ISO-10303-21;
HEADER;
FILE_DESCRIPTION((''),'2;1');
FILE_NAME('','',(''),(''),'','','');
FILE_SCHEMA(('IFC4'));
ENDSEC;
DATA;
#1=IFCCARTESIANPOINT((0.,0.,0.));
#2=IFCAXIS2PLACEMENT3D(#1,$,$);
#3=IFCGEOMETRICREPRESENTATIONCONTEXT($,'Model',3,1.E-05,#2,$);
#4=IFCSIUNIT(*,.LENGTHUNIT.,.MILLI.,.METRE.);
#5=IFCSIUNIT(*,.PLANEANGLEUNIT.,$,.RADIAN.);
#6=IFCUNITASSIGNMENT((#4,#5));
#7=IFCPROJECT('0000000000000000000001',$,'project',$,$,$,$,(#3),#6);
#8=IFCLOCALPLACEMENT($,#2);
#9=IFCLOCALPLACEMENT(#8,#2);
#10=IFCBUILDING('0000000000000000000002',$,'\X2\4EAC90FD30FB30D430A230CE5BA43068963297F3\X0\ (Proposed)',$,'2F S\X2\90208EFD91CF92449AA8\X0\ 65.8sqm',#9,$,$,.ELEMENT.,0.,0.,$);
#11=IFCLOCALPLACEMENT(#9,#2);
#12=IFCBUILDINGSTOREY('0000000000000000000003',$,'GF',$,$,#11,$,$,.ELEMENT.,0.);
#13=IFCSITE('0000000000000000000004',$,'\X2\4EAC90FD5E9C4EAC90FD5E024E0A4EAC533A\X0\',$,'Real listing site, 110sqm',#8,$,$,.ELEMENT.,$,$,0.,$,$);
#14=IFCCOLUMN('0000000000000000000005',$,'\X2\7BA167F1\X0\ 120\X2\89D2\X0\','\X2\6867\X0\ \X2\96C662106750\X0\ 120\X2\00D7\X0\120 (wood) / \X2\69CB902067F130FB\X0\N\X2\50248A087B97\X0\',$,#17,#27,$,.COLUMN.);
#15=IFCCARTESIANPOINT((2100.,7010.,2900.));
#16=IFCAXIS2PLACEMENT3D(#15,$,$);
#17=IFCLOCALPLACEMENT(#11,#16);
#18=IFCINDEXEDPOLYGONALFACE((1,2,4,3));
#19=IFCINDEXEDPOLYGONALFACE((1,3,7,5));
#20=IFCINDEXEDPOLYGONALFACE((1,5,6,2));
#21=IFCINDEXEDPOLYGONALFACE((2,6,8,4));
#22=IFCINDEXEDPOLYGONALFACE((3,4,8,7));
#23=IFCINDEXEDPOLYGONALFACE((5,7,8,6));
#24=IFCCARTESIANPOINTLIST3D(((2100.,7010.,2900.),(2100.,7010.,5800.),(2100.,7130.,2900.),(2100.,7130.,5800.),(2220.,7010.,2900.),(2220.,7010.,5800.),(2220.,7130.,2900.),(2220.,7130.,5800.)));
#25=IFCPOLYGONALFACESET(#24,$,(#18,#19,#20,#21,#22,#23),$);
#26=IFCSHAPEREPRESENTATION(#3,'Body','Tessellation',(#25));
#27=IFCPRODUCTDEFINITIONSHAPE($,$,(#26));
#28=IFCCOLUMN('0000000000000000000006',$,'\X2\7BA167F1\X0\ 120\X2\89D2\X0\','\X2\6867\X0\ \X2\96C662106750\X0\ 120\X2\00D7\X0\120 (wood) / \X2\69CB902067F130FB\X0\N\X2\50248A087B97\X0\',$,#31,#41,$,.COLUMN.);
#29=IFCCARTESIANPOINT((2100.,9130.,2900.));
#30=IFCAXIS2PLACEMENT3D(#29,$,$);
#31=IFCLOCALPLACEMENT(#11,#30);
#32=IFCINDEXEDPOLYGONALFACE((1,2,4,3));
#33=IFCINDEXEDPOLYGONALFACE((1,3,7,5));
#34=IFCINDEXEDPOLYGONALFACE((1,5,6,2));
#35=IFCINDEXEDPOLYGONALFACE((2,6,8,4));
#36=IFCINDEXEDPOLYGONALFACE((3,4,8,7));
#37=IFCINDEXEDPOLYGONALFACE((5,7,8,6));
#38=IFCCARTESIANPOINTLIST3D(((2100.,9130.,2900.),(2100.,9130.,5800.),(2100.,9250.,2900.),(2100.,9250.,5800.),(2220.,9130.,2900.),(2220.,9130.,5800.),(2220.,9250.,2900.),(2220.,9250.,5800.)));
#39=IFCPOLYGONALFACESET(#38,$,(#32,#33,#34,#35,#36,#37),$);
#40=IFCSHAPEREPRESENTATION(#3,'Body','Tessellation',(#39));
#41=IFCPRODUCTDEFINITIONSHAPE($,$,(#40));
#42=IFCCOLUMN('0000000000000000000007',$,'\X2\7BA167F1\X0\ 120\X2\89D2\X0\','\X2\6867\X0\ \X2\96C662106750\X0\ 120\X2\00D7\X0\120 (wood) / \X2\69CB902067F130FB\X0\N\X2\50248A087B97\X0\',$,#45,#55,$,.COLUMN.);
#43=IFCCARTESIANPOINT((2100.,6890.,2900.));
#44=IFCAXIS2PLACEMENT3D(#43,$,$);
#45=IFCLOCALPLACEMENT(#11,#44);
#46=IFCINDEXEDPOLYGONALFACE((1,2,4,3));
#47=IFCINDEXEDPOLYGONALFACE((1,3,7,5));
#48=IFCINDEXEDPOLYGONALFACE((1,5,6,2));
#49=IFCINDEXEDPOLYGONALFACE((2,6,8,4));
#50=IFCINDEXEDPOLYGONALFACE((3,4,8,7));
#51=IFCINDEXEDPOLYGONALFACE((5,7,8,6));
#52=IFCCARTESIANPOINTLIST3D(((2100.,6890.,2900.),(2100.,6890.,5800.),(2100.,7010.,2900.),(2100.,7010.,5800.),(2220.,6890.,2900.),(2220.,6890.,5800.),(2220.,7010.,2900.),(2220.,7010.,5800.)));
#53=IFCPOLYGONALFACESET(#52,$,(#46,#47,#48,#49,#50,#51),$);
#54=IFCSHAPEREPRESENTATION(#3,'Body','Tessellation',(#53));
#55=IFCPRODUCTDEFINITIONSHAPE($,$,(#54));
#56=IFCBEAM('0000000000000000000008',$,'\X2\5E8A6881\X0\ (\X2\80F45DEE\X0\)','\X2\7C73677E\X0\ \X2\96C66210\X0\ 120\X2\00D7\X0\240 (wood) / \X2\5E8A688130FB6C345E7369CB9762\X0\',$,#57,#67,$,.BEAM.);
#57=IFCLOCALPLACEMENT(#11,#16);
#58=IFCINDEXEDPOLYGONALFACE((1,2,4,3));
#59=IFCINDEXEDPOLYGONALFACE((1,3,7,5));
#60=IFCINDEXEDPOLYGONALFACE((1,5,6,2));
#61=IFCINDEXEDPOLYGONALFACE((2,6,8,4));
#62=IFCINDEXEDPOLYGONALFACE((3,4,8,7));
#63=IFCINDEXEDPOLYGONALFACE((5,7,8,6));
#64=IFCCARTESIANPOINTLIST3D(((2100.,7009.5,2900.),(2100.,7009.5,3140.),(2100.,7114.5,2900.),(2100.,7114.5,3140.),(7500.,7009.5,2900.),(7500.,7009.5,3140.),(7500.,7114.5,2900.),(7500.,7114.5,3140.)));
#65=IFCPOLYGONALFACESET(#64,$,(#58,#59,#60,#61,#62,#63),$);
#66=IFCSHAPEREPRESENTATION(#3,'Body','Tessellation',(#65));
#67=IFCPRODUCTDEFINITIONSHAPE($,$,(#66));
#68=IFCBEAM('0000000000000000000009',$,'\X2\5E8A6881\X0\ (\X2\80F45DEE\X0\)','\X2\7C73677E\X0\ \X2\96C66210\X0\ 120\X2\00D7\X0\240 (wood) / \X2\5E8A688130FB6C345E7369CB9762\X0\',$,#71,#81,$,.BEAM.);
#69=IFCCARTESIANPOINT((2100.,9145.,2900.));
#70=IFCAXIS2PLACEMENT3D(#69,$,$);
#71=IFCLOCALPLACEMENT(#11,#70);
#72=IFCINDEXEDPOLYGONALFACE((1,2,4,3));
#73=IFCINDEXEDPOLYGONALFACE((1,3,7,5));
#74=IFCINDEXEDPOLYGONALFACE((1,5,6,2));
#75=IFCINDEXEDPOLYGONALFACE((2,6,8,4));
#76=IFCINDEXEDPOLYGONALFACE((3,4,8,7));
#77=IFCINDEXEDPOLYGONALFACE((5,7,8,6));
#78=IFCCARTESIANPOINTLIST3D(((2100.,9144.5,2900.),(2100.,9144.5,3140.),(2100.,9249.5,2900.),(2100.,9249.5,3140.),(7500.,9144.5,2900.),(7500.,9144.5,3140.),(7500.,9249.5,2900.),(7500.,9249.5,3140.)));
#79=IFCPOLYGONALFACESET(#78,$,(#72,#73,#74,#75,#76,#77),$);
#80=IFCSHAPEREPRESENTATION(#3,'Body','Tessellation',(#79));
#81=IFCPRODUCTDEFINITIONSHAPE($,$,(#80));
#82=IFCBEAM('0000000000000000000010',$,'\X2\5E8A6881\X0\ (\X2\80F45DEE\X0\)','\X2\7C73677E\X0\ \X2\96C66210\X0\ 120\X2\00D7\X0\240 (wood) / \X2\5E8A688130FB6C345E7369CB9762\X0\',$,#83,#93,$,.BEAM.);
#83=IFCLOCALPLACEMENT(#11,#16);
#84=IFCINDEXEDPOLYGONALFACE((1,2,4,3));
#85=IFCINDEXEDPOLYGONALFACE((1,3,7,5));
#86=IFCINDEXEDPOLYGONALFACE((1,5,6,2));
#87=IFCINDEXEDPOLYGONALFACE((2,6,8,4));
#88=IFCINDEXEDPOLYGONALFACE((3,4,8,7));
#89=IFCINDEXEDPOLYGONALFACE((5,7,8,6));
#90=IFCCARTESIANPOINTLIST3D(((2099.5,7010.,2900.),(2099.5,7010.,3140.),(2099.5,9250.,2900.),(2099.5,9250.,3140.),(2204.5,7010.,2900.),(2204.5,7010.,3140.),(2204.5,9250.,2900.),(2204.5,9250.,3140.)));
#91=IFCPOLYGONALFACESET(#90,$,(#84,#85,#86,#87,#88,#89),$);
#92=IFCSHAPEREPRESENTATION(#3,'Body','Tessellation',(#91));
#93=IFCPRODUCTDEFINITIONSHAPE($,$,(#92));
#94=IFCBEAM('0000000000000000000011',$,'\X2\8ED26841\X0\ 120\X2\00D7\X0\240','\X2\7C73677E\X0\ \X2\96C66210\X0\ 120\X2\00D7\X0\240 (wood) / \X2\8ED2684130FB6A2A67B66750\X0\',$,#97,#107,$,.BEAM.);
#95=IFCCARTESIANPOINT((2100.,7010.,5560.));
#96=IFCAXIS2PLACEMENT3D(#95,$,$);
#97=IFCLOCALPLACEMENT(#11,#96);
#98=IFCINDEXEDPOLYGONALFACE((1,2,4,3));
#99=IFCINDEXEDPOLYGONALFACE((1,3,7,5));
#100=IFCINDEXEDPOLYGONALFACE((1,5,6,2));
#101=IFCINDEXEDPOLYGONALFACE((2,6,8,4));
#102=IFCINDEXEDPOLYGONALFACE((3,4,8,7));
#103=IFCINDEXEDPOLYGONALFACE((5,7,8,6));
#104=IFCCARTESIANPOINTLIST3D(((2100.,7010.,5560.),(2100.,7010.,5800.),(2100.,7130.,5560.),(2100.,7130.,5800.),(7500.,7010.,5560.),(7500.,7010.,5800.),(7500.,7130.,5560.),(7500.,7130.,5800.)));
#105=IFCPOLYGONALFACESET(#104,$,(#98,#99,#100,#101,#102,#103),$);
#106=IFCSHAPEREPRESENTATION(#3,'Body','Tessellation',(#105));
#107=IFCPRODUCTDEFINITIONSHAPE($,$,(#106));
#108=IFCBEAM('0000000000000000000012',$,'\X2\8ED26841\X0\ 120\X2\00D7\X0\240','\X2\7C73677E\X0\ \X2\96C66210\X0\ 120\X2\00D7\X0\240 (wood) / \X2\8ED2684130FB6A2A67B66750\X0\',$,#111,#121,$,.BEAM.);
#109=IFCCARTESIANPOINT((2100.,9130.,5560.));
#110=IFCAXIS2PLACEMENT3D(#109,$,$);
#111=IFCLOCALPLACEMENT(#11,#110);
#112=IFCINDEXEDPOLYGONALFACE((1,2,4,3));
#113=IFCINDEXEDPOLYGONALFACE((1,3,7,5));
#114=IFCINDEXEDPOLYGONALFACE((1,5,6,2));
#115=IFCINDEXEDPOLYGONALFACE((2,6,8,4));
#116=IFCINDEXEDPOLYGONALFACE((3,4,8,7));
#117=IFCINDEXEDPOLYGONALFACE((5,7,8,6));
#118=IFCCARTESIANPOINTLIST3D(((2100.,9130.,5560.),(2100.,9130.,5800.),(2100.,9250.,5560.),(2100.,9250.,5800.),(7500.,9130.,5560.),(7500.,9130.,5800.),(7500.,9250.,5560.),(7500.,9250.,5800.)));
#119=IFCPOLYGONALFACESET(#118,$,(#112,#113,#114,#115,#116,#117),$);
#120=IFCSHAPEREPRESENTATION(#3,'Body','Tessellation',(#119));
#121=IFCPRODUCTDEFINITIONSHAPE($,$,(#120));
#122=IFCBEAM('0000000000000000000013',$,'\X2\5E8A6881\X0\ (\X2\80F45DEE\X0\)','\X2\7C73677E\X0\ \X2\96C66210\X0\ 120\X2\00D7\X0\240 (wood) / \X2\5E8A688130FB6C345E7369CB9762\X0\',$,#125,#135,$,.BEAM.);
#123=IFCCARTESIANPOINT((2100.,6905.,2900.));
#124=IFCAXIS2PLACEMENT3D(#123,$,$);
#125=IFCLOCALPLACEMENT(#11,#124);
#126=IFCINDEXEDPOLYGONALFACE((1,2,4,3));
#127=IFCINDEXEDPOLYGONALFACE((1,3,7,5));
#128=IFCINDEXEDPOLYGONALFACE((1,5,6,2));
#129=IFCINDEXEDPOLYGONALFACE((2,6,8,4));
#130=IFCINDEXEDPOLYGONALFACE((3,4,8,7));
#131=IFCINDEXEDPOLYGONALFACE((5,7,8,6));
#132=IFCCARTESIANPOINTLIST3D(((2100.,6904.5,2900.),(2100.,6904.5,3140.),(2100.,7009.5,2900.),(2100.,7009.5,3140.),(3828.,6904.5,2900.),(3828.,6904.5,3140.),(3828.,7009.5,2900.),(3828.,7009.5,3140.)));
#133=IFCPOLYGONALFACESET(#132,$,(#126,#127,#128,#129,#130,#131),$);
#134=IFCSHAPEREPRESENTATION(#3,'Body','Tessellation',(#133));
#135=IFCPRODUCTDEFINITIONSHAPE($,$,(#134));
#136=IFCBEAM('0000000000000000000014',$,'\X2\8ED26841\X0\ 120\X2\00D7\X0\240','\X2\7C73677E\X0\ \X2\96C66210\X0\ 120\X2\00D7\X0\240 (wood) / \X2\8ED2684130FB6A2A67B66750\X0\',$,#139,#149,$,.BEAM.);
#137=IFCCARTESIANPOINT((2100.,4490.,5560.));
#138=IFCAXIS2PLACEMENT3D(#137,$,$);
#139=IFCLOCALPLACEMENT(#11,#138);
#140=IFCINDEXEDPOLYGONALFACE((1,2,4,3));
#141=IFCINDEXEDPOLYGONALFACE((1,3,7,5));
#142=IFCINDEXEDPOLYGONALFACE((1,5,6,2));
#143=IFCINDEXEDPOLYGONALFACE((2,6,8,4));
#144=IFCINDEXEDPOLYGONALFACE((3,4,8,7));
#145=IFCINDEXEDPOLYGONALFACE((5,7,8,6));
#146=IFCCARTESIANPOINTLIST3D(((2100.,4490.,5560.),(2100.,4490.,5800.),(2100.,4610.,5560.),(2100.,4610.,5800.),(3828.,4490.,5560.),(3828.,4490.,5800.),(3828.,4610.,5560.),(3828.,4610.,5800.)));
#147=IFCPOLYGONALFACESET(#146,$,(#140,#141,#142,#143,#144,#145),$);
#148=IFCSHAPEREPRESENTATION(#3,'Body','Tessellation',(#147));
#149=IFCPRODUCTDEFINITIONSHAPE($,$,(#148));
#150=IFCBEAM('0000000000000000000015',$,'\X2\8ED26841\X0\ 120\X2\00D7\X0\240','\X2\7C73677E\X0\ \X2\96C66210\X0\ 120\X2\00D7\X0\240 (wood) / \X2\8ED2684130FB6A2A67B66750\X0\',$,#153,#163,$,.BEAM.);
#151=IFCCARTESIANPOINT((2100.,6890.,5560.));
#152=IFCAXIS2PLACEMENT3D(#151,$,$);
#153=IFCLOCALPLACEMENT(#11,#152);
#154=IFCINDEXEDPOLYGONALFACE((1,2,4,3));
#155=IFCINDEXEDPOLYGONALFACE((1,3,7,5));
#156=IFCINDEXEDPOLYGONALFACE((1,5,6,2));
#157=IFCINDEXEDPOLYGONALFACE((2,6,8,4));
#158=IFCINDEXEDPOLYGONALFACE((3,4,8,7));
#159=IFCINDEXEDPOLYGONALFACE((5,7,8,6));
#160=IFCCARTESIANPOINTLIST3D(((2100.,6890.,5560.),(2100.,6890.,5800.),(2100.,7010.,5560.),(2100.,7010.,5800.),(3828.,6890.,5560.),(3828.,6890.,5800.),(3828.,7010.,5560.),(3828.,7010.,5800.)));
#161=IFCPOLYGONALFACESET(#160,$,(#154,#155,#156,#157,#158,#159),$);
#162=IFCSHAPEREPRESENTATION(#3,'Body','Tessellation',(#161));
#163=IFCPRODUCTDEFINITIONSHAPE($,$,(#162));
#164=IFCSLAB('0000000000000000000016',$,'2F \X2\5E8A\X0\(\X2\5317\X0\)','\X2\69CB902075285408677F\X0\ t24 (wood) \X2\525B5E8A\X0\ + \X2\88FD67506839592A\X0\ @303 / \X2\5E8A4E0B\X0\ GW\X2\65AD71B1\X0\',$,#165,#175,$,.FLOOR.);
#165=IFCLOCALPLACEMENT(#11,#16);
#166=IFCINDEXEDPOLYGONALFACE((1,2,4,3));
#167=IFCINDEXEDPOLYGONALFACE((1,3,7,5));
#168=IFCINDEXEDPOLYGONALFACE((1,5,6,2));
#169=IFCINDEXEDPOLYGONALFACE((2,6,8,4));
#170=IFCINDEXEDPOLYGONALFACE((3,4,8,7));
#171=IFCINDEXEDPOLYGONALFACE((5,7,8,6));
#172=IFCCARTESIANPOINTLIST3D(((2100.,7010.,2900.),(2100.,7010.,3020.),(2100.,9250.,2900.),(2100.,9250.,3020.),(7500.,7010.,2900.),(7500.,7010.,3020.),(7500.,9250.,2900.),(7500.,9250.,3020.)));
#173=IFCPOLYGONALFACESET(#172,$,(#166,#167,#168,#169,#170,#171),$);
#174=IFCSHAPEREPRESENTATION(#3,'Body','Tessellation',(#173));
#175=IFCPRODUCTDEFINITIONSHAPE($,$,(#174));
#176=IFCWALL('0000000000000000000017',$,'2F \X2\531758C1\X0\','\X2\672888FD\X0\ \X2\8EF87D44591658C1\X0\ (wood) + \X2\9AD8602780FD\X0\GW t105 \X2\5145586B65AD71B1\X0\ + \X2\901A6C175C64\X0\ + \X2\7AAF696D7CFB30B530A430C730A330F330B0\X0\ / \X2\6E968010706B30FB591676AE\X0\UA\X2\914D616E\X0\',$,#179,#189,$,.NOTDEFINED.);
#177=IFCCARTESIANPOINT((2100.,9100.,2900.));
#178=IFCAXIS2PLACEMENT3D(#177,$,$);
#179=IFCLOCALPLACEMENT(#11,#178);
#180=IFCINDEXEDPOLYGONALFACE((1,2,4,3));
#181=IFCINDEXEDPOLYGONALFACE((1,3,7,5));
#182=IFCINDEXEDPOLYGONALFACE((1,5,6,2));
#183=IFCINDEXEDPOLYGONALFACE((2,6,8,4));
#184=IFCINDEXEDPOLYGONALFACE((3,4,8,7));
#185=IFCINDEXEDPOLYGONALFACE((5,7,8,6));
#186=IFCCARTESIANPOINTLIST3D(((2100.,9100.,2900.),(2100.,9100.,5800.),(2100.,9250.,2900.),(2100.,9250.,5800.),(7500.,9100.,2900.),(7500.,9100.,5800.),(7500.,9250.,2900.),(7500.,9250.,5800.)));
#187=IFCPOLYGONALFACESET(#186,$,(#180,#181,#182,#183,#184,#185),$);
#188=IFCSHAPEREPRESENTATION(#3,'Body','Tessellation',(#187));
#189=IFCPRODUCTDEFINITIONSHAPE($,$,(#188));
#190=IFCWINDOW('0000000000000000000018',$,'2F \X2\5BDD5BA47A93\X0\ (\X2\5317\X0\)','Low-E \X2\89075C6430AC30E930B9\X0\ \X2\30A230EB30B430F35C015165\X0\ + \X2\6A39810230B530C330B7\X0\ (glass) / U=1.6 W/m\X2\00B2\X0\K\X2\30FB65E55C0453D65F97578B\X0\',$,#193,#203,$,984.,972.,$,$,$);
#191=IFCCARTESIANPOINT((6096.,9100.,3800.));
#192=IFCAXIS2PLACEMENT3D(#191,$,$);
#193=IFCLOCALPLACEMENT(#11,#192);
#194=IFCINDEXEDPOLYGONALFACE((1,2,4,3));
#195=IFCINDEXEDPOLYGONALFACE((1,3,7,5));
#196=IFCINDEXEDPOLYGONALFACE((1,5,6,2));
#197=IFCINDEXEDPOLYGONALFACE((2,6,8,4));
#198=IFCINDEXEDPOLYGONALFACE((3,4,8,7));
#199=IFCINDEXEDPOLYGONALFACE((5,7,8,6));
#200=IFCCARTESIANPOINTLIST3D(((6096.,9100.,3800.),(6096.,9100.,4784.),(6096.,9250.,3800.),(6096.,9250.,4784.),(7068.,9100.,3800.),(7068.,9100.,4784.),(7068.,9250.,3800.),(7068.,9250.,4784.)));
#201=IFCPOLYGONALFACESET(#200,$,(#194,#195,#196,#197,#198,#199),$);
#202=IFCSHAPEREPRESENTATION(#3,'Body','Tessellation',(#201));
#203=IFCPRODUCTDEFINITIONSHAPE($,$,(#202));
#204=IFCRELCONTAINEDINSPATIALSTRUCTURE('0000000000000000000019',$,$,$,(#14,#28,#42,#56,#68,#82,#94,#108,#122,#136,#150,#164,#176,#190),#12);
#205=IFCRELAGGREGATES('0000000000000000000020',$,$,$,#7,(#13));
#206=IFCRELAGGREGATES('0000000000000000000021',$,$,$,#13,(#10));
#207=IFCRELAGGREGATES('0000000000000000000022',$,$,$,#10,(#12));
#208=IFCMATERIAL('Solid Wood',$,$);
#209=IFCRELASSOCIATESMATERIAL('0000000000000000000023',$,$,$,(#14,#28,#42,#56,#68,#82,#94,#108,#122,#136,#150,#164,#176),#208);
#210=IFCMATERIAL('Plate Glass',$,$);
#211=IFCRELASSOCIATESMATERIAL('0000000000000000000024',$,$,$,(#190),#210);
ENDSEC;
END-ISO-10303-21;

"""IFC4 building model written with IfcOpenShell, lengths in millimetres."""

from ifc_helpers import new_model, si_unit, frame, frame_2d, origin, place, context, project, spatial, rectangle, extrude, material, element, fill, save


model = new_model("IFC4")

# Units and contexts
model_context = context("Model", 3, precision=1e-05, world=origin())
ifc_project = project(units=[si_unit("LENGTHUNIT", "METRE", prefix="MILLI"), si_unit("PLANEANGLEUNIT", "RADIAN")], contexts=[model_context])

# Site, building, storey
site_placement = place(None, origin())
site = spatial("IfcSite", under=ifc_project, at=site_placement, Name="京都府京都市上京区", ObjectType="Real listing site, 110sqm", CompositionType="ELEMENT", RefElevation=0.0)
building_placement = place(site_placement, origin())
building = spatial("IfcBuilding", under=site, at=building_placement, Name="京都・ピアノ室と防音 (Proposed)", ObjectType="2F S造軽量鉄骨 65.8sqm", CompositionType="ELEMENT", ElevationOfRefHeight=0.0, ElevationOfTerrain=0.0)
storey_placement = place(building_placement, origin())
storey = spatial("IfcBuildingStorey", under=building, at=storey_placement, Name="GF", CompositionType="ELEMENT", Elevation=0.0)

# Columns
ifc_material_1 = material(Name="Solid Wood")
column_1_placement = place(storey_placement, frame((2100.0, 7010.0, 2900.0)))
element("IfcColumn", 1, at=column_1_placement, inside=storey, material=ifc_material_1, Name="管柱 120角", Description="桧 集成材 120×120 (wood) / 構造柱・N値計算", PredefinedType="COLUMN", context=model_context, shape_type="SweptSolid", body=[
    extrude(rectangle(XDim=120.0, YDim=120.0, at=frame_2d((60.0, 60.0))), frame((2100.0, 7010.0, 2900.0)), (0.0, 0.0, 1.0), 2900.0),
])
column_2_placement = place(storey_placement, frame((2100.0, 9130.0, 2900.0)))
element("IfcColumn", 2, at=column_2_placement, inside=storey, material=ifc_material_1, Name="管柱 120角", Description="桧 集成材 120×120 (wood) / 構造柱・N値計算", PredefinedType="COLUMN", context=model_context, shape_type="SweptSolid", body=[
    extrude(rectangle(XDim=120.0, YDim=120.0, at=frame_2d((60.0, 60.0))), frame((2100.0, 9130.0, 2900.0)), (0.0, 0.0, 1.0), 2900.0),
])
column_3_placement = place(storey_placement, frame((2100.0, 6890.0, 2900.0)))
element("IfcColumn", 3, at=column_3_placement, inside=storey, material=ifc_material_1, Name="管柱 120角", Description="桧 集成材 120×120 (wood) / 構造柱・N値計算", PredefinedType="COLUMN", context=model_context, shape_type="SweptSolid", body=[
    extrude(rectangle(XDim=120.0, YDim=120.0, at=frame_2d((60.0, 60.0))), frame((2100.0, 6890.0, 2900.0)), (0.0, 0.0, 1.0), 2900.0),
])

# Beams
beam_1_placement = place(storey_placement, frame((2100.0, 7010.0, 2900.0)))
element("IfcBeam", 4, at=beam_1_placement, inside=storey, material=ifc_material_1, Name="床梁 (胴差)", Description="米松 集成 120×240 (wood) / 床梁・水平構面", PredefinedType="BEAM", context=model_context, shape_type="SweptSolid", body=[
    extrude(rectangle(XDim=5400.0, YDim=105.0, at=frame_2d((2700.0, 52.0))), frame((2100.0, 7010.0, 2900.0)), (0.0, 0.0, 1.0), 240.0),
])
beam_2_placement = place(storey_placement, frame((2100.0, 9145.0, 2900.0)))
element("IfcBeam", 5, at=beam_2_placement, inside=storey, material=ifc_material_1, Name="床梁 (胴差)", Description="米松 集成 120×240 (wood) / 床梁・水平構面", PredefinedType="BEAM", context=model_context, shape_type="SweptSolid", body=[
    extrude(rectangle(XDim=5400.0, YDim=105.0, at=frame_2d((2700.0, 52.0))), frame((2100.0, 9145.0, 2900.0)), (0.0, 0.0, 1.0), 240.0),
])
beam_3_placement = place(storey_placement, frame((2100.0, 7010.0, 2900.0)))
element("IfcBeam", 6, at=beam_3_placement, inside=storey, material=ifc_material_1, Name="床梁 (胴差)", Description="米松 集成 120×240 (wood) / 床梁・水平構面", PredefinedType="BEAM", context=model_context, shape_type="SweptSolid", body=[
    extrude(rectangle(XDim=105.0, YDim=2240.0, at=frame_2d((52.0, 1120.0))), frame((2100.0, 7010.0, 2900.0)), (0.0, 0.0, 1.0), 240.0),
])
beam_4_placement = place(storey_placement, frame((2100.0, 7010.0, 5560.0)))
element("IfcBeam", 7, at=beam_4_placement, inside=storey, material=ifc_material_1, Name="軒桁 120×240", Description="米松 集成 120×240 (wood) / 軒桁・横架材", PredefinedType="BEAM", context=model_context, shape_type="SweptSolid", body=[
    extrude(rectangle(XDim=5400.0, YDim=120.0, at=frame_2d((2700.0, 60.0))), frame((2100.0, 7010.0, 5560.0)), (0.0, 0.0, 1.0), 240.0),
])
beam_5_placement = place(storey_placement, frame((2100.0, 9130.0, 5560.0)))
element("IfcBeam", 8, at=beam_5_placement, inside=storey, material=ifc_material_1, Name="軒桁 120×240", Description="米松 集成 120×240 (wood) / 軒桁・横架材", PredefinedType="BEAM", context=model_context, shape_type="SweptSolid", body=[
    extrude(rectangle(XDim=5400.0, YDim=120.0, at=frame_2d((2700.0, 60.0))), frame((2100.0, 9130.0, 5560.0)), (0.0, 0.0, 1.0), 240.0),
])
beam_6_placement = place(storey_placement, frame((2100.0, 6905.0, 2900.0)))
element("IfcBeam", 9, at=beam_6_placement, inside=storey, material=ifc_material_1, Name="床梁 (胴差)", Description="米松 集成 120×240 (wood) / 床梁・水平構面", PredefinedType="BEAM", context=model_context, shape_type="SweptSolid", body=[
    extrude(rectangle(XDim=1728.0, YDim=105.0, at=frame_2d((864.0, 52.0))), frame((2100.0, 6905.0, 2900.0)), (0.0, 0.0, 1.0), 240.0),
])
beam_7_placement = place(storey_placement, frame((2100.0, 4490.0, 5560.0)))
element("IfcBeam", 10, at=beam_7_placement, inside=storey, material=ifc_material_1, Name="軒桁 120×240", Description="米松 集成 120×240 (wood) / 軒桁・横架材", PredefinedType="BEAM", context=model_context, shape_type="SweptSolid", body=[
    extrude(rectangle(XDim=1728.0, YDim=120.0, at=frame_2d((864.0, 60.0))), frame((2100.0, 4490.0, 5560.0)), (0.0, 0.0, 1.0), 240.0),
])
beam_8_placement = place(storey_placement, frame((2100.0, 6890.0, 5560.0)))
element("IfcBeam", 11, at=beam_8_placement, inside=storey, material=ifc_material_1, Name="軒桁 120×240", Description="米松 集成 120×240 (wood) / 軒桁・横架材", PredefinedType="BEAM", context=model_context, shape_type="SweptSolid", body=[
    extrude(rectangle(XDim=1728.0, YDim=120.0, at=frame_2d((864.0, 60.0))), frame((2100.0, 6890.0, 5560.0)), (0.0, 0.0, 1.0), 240.0),
])

# Slab
slab_placement = place(storey_placement, frame((2100.0, 7010.0, 2900.0)))
element("IfcSlab", 12, at=slab_placement, inside=storey, material=ifc_material_1, Name="2F 床(北)", Description="構造用合板 t24 (wood) 剛床 + 製材根太 @303 / 床下 GW断熱", PredefinedType="FLOOR", context=model_context, shape_type="SweptSolid", body=[
    extrude(rectangle(XDim=5400.0, YDim=2240.0, at=frame_2d((2700.0, 1120.0))), frame((2100.0, 7010.0, 2900.0)), (0.0, 0.0, 1.0), 120.0),
])

# Wall, opening, window
wall_placement = place(storey_placement, frame((2100.0, 9100.0, 2900.0)))
wall = element("IfcWall", 13, at=wall_placement, inside=storey, material=ifc_material_1, Name="2F 北壁", Description="木製 軸組外壁 (wood) + 高性能GW t105 充填断熱 + 通気層 + 窯業系サイディング / 準耐火・外皮UA配慮", PredefinedType="NOTDEFINED", context=model_context, shape_type="SweptSolid", body=[
    extrude(rectangle(XDim=5400.0, YDim=150.0, at=frame_2d((2700.0, 75.0))), frame((2100.0, 9100.0, 2900.0)), (0.0, 0.0, 1.0), 2900.0),
])
opening_placement = place(storey_placement, frame((6096.0, 9100.0, 3800.0)))
opening = element("IfcOpeningElement", 14, at=opening_placement, cuts=wall, PredefinedType="NOTDEFINED", context=model_context, shape_type="SweptSolid", body=[
    extrude(rectangle(XDim=972.0, YDim=150.0, at=frame_2d((486.0, 75.0))), frame((6096.0, 9100.0, 3800.0)), (0.0, 0.0, 1.0), 984.0),
])
ifc_material_2 = material(Name="Plate Glass")
window_placement = place(storey_placement, frame((6096.0, 9100.0, 3800.0)))
window = element("IfcWindow", 15, at=window_placement, inside=storey, material=ifc_material_2, Name="2F 寝室窓 (北)", Description="Low-E 複層ガラス アルゴン封入 + 樹脂サッシ (glass) / U=1.6 W/m²K・日射取得型", OverallHeight=984.0, OverallWidth=972.0, context=model_context, shape_type="SweptSolid", body=[
    extrude(rectangle(XDim=972.0, YDim=150.0, at=frame_2d((486.0, 75.0))), frame((6096.0, 9100.0, 3800.0)), (0.0, 0.0, 1.0), 984.0),
])
fill(opening, window)

save(model, "model.ifc")
